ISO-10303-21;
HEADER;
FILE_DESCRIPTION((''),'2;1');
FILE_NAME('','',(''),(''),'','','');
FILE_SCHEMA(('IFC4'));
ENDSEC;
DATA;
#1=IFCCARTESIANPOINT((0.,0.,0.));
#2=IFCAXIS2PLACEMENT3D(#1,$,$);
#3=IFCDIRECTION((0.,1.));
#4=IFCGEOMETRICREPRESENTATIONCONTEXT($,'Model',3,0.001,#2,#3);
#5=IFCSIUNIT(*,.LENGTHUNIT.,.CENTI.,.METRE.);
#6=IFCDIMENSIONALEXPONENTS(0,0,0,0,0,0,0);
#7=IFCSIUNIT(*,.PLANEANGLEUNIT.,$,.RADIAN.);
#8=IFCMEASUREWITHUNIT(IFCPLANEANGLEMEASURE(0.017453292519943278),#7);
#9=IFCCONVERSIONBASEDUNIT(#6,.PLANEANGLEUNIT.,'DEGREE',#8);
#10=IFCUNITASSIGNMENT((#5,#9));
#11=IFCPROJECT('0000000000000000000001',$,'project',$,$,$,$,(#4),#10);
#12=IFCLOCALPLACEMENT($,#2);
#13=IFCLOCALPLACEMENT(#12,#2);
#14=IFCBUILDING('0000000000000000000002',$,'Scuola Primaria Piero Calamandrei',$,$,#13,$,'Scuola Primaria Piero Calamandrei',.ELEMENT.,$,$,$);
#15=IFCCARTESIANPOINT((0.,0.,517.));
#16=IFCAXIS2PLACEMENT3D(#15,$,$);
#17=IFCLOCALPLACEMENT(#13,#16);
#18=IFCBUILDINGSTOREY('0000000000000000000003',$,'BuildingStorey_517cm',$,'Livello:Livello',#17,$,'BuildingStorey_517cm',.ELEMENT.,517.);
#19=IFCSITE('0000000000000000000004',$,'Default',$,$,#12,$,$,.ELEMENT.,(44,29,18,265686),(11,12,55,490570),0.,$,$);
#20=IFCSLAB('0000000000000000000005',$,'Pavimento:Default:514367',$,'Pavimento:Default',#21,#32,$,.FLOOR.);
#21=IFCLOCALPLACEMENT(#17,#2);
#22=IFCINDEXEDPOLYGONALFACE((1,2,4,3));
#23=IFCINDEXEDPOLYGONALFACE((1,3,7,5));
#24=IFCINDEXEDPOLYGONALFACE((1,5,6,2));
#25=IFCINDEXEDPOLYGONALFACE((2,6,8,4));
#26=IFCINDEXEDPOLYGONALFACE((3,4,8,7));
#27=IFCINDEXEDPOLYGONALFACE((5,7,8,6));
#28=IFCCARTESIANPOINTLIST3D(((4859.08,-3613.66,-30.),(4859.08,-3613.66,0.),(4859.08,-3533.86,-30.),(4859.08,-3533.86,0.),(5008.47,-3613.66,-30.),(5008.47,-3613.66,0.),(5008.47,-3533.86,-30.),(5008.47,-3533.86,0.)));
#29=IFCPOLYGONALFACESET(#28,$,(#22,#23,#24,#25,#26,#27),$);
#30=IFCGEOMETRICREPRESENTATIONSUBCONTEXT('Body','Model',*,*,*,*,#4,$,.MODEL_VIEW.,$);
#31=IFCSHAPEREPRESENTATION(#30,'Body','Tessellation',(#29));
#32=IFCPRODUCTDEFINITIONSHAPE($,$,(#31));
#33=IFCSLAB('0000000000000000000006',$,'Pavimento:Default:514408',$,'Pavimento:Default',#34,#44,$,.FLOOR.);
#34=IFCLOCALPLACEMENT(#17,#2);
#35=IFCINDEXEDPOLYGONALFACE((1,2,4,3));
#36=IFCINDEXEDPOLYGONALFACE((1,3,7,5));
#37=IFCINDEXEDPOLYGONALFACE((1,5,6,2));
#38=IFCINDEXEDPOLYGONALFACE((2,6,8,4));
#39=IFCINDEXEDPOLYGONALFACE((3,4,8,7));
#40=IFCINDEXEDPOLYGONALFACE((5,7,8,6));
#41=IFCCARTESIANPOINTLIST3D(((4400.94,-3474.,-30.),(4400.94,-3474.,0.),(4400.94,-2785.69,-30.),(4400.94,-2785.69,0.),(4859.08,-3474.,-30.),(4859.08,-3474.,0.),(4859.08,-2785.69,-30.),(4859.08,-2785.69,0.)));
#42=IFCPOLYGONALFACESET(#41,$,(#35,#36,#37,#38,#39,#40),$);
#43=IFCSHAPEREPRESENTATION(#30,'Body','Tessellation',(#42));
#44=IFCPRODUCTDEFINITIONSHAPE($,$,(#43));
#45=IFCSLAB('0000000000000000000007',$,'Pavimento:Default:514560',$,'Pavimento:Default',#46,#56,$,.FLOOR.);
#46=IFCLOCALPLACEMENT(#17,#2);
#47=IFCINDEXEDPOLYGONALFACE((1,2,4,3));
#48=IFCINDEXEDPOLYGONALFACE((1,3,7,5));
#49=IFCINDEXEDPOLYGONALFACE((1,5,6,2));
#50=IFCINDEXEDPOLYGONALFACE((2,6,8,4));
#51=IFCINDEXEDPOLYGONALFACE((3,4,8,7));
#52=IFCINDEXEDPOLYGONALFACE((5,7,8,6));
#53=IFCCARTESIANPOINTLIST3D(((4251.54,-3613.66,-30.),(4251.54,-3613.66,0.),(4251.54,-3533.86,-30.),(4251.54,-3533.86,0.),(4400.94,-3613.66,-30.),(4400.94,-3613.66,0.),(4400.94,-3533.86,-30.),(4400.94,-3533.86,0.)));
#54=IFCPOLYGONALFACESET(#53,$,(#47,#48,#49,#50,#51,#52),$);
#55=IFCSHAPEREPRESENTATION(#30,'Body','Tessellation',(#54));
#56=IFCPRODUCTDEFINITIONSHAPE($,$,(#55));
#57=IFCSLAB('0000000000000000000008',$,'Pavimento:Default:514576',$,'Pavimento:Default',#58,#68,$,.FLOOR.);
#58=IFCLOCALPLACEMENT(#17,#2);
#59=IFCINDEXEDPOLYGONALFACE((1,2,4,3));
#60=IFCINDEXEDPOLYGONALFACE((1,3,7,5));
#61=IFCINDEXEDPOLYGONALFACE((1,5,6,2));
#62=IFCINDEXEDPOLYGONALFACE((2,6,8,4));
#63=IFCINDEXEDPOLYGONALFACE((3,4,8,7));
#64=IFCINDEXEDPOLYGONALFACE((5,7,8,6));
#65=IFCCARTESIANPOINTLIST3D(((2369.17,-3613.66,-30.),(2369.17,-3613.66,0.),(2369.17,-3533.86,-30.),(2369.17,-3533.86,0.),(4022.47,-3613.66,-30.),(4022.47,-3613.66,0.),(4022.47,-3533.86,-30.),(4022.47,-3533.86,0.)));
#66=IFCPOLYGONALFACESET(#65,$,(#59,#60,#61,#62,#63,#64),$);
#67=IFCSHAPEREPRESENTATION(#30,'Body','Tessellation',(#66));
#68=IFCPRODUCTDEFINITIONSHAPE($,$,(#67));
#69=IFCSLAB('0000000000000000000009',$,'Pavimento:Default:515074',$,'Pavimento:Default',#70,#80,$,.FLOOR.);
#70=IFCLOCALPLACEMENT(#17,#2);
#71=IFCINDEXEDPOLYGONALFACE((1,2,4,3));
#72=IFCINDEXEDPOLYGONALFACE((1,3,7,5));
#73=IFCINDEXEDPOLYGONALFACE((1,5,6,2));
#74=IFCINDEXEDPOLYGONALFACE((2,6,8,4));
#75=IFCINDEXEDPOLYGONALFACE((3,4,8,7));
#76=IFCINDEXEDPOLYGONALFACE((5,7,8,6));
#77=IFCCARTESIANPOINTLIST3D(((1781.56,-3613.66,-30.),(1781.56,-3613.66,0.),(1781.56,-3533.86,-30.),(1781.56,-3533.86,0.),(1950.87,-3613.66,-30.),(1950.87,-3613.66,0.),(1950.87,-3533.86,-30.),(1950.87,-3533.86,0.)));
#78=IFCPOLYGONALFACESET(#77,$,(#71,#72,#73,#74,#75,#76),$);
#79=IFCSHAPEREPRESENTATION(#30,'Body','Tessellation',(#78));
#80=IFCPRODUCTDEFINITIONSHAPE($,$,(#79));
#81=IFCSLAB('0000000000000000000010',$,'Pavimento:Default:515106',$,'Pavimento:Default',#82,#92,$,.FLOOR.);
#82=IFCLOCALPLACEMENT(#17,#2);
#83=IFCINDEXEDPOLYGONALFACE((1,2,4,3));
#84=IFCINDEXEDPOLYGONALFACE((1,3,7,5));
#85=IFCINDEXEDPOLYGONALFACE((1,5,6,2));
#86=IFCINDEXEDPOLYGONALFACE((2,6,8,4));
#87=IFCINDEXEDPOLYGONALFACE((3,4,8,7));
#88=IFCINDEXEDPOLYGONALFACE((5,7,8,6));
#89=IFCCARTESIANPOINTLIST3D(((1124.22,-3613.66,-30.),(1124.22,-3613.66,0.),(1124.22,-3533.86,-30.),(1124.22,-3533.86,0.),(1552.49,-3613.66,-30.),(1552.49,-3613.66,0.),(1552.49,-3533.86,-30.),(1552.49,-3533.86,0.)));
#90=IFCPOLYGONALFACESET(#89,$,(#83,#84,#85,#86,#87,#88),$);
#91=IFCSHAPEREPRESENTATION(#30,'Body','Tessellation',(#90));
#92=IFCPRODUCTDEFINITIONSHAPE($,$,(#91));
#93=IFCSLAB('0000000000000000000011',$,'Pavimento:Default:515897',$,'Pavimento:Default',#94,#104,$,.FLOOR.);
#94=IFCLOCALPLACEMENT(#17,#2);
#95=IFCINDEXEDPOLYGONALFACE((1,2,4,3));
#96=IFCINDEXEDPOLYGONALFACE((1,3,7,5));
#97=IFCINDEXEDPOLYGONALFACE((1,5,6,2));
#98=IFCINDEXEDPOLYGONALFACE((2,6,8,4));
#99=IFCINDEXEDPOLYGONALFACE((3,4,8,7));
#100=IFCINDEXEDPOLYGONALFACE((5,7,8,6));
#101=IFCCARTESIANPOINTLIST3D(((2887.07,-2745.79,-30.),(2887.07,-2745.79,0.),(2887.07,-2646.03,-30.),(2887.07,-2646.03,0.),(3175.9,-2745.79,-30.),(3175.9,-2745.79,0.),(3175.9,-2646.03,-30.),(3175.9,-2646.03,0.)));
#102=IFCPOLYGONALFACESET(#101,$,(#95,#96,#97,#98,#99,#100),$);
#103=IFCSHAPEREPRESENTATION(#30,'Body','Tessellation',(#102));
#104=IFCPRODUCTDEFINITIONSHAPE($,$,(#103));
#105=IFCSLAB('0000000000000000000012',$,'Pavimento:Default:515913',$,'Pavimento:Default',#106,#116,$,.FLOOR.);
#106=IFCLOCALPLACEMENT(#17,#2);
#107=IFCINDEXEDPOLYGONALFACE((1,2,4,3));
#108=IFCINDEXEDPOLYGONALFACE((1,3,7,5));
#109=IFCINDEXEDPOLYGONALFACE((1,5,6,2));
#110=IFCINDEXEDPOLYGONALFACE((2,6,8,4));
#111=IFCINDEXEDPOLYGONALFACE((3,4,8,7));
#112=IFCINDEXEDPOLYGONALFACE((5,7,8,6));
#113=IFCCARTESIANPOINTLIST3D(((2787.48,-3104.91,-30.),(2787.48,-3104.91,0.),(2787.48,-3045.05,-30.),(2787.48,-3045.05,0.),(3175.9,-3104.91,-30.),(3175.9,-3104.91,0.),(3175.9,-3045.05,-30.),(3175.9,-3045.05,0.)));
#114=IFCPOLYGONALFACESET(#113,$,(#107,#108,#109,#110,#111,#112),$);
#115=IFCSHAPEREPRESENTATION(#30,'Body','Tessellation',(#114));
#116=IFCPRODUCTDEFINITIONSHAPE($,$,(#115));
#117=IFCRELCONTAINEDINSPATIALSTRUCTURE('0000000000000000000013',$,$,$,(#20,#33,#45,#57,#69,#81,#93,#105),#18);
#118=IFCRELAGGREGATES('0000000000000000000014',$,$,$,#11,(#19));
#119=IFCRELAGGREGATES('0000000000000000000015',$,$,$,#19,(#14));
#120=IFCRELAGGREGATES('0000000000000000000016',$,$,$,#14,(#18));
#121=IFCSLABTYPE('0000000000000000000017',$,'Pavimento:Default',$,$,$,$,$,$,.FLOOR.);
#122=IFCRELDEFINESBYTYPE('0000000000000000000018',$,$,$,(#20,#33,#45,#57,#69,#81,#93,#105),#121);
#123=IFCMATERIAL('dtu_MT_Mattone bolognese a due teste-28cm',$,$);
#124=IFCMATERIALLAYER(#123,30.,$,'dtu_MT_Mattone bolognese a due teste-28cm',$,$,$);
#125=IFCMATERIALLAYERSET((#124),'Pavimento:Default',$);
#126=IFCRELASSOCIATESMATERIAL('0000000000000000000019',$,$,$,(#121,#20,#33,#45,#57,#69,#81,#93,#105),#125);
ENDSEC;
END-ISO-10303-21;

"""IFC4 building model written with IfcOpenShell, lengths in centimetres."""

from ifc_helpers import new_model, entity, si_unit, converted_unit, direction, frame, frame_2d, origin, origin_2d_with_axis, place, context, subcontext, project, spatial, rectangle, extrude, material, layer, layer_set, layer_usage, type_object, element, save


model = new_model("IFC4")

# Units and contexts
model_context = context("Model", 3, precision=0.001, world=origin(), true_north=direction((0.0, 1.0)))
body_context = subcontext(model_context, "Body", "Model", "MODEL_VIEW")
ifc_project = project(units=[si_unit("LENGTHUNIT", "METRE", prefix="CENTI"), converted_unit("PLANEANGLEUNIT", "DEGREE", entity("IfcPlaneAngleMeasure", 0.017453292519943278), si_unit("PLANEANGLEUNIT", "RADIAN"), dimensions=[0, 0, 0, 0, 0, 0, 0])], contexts=[model_context])

# Site, building, storey
site_placement = place(None, origin())
site = spatial("IfcSite", under=ifc_project, at=site_placement, Name="Default", CompositionType="ELEMENT", RefLatitude=(44, 29, 18, 265686), RefLongitude=(11, 12, 55, 490570), RefElevation=0.0)
building_placement = place(site_placement, origin())
building = spatial("IfcBuilding", under=site, at=building_placement, Name="Scuola Primaria Piero Calamandrei", LongName="Scuola Primaria Piero Calamandrei", CompositionType="ELEMENT")
storey_placement = place(building_placement, frame((0.0, 0.0, 517.0)))
storey = spatial("IfcBuildingStorey", under=building, at=storey_placement, Name="BuildingStorey_517cm", ObjectType="Livello:Livello", LongName="BuildingStorey_517cm", CompositionType="ELEMENT", Elevation=517.0)

# Slabs
ifc_material_1 = material(Name="dtu_MT_Mattone bolognese a due teste-28cm")
ifc_layer_1 = layer(ifc_material_1, 30.0, Name="dtu_MT_Mattone bolognese a due teste-28cm")
ifc_layer_set_1 = layer_set([ifc_layer_1], Name="Pavimento:Default")
slab_type_1 = type_object("IfcSlabType", Name="Pavimento:Default", PredefinedType="FLOOR", material=ifc_layer_set_1)
ifc_layer_usage_1 = layer_usage(ifc_layer_set_1, "AXIS3", "POSITIVE", 0.0)
slab_1_placement = place(storey_placement, origin())
element("IfcSlab", 1, at=slab_1_placement, inside=storey, type_object=slab_type_1, material=ifc_layer_usage_1, Name="Pavimento:Default:514367", ObjectType="Pavimento:Default", PredefinedType="FLOOR", context=body_context, shape_type="SweptSolid", body=[
    extrude(rectangle(XDim=79.8, YDim=149.39, at=origin_2d_with_axis()), frame((4933.78, -3573.76, 0.0), z_axis=(0.0, 0.0, -1.0), x_axis=(0.0, 1.0, 0.0)), (0.0, 0.0, 1.0), 30.0),
])
ifc_layer_usage_2 = layer_usage(ifc_layer_set_1, "AXIS3", "POSITIVE", 0.0)
slab_2_placement = place(storey_placement, origin())
element("IfcSlab", 2, at=slab_2_placement, inside=storey, type_object=slab_type_1, material=ifc_layer_usage_2, Name="Pavimento:Default:514408", ObjectType="Pavimento:Default", PredefinedType="FLOOR", context=body_context, shape_type="SweptSolid", body=[
    extrude(rectangle(XDim=688.31, YDim=458.14, at=frame_2d((0.0, 0.0), x_axis=(1.0, 0.0))), frame((4630.01, -3129.85, 0.0), z_axis=(0.0, 0.0, -1.0), x_axis=(0.0, 1.0, 0.0)), (0.0, 0.0, 1.0), 30.0),
])
ifc_layer_usage_3 = layer_usage(ifc_layer_set_1, "AXIS3", "POSITIVE", 0.0)
slab_3_placement = place(storey_placement, origin())
element("IfcSlab", 3, at=slab_3_placement, inside=storey, type_object=slab_type_1, material=ifc_layer_usage_3, Name="Pavimento:Default:514560", ObjectType="Pavimento:Default", PredefinedType="FLOOR", context=body_context, shape_type="SweptSolid", body=[
    extrude(rectangle(XDim=79.8, YDim=149.39, at=origin_2d_with_axis()), frame((4326.24, -3573.76, 0.0), z_axis=(0.0, 0.0, -1.0), x_axis=(0.0, 1.0, 0.0)), (0.0, 0.0, 1.0), 30.0),
])
ifc_layer_usage_4 = layer_usage(ifc_layer_set_1, "AXIS3", "POSITIVE", 0.0)
slab_4_placement = place(storey_placement, origin())
element("IfcSlab", 4, at=slab_4_placement, inside=storey, type_object=slab_type_1, material=ifc_layer_usage_4, Name="Pavimento:Default:514576", ObjectType="Pavimento:Default", PredefinedType="FLOOR", context=body_context, shape_type="SweptSolid", body=[
    extrude(rectangle(XDim=79.8, YDim=1653.3, at=frame_2d((0.0, 0.0), x_axis=(1.0, 0.0))), frame((3195.82, -3573.76, 0.0), z_axis=(0.0, 0.0, -1.0), x_axis=(0.0, 1.0, 0.0)), (0.0, 0.0, 1.0), 30.0),
])
ifc_layer_usage_5 = layer_usage(ifc_layer_set_1, "AXIS3", "POSITIVE", 0.0)
slab_5_placement = place(storey_placement, origin())
element("IfcSlab", 5, at=slab_5_placement, inside=storey, type_object=slab_type_1, material=ifc_layer_usage_5, Name="Pavimento:Default:515074", ObjectType="Pavimento:Default", PredefinedType="FLOOR", context=body_context, shape_type="SweptSolid", body=[
    extrude(rectangle(XDim=79.8, YDim=169.31, at=origin_2d_with_axis()), frame((1866.21, -3573.76, 0.0), z_axis=(0.0, 0.0, -1.0), x_axis=(0.0, 1.0, 0.0)), (0.0, 0.0, 1.0), 30.0),
])
ifc_layer_usage_6 = layer_usage(ifc_layer_set_1, "AXIS3", "POSITIVE", 0.0)
slab_6_placement = place(storey_placement, origin())
element("IfcSlab", 6, at=slab_6_placement, inside=storey, type_object=slab_type_1, material=ifc_layer_usage_6, Name="Pavimento:Default:515106", ObjectType="Pavimento:Default", PredefinedType="FLOOR", context=body_context, shape_type="SweptSolid", body=[
    extrude(rectangle(XDim=79.8, YDim=428.26, at=frame_2d((0.0, 0.0), x_axis=(1.0, 0.0))), frame((1338.35, -3573.76, 0.0), z_axis=(0.0, 0.0, -1.0), x_axis=(0.0, 1.0, 0.0)), (0.0, 0.0, 1.0), 30.0),
])
ifc_layer_usage_7 = layer_usage(ifc_layer_set_1, "AXIS3", "POSITIVE", 0.0)
slab_7_placement = place(storey_placement, origin())
element("IfcSlab", 7, at=slab_7_placement, inside=storey, type_object=slab_type_1, material=ifc_layer_usage_7, Name="Pavimento:Default:515897", ObjectType="Pavimento:Default", PredefinedType="FLOOR", context=body_context, shape_type="SweptSolid", body=[
    extrude(rectangle(XDim=99.76, YDim=288.83, at=origin_2d_with_axis()), frame((3031.49, -2695.91, 0.0), z_axis=(0.0, 0.0, -1.0), x_axis=(0.0, 1.0, 0.0)), (0.0, 0.0, 1.0), 30.0),
])
ifc_layer_usage_8 = layer_usage(ifc_layer_set_1, "AXIS3", "POSITIVE", 0.0)
slab_8_placement = place(storey_placement, origin())
element("IfcSlab", 8, at=slab_8_placement, inside=storey, type_object=slab_type_1, material=ifc_layer_usage_8, Name="Pavimento:Default:515913", ObjectType="Pavimento:Default", PredefinedType="FLOOR", context=body_context, shape_type="SweptSolid", body=[
    extrude(rectangle(XDim=59.85, YDim=388.42, at=frame_2d((0.0, 0.0), x_axis=(1.0, 0.0))), frame((2981.69, -3074.98, 0.0), z_axis=(0.0, 0.0, -1.0), x_axis=(0.0, 1.0, 0.0)), (0.0, 0.0, 1.0), 30.0),
])

save(model, "model.ifc")
